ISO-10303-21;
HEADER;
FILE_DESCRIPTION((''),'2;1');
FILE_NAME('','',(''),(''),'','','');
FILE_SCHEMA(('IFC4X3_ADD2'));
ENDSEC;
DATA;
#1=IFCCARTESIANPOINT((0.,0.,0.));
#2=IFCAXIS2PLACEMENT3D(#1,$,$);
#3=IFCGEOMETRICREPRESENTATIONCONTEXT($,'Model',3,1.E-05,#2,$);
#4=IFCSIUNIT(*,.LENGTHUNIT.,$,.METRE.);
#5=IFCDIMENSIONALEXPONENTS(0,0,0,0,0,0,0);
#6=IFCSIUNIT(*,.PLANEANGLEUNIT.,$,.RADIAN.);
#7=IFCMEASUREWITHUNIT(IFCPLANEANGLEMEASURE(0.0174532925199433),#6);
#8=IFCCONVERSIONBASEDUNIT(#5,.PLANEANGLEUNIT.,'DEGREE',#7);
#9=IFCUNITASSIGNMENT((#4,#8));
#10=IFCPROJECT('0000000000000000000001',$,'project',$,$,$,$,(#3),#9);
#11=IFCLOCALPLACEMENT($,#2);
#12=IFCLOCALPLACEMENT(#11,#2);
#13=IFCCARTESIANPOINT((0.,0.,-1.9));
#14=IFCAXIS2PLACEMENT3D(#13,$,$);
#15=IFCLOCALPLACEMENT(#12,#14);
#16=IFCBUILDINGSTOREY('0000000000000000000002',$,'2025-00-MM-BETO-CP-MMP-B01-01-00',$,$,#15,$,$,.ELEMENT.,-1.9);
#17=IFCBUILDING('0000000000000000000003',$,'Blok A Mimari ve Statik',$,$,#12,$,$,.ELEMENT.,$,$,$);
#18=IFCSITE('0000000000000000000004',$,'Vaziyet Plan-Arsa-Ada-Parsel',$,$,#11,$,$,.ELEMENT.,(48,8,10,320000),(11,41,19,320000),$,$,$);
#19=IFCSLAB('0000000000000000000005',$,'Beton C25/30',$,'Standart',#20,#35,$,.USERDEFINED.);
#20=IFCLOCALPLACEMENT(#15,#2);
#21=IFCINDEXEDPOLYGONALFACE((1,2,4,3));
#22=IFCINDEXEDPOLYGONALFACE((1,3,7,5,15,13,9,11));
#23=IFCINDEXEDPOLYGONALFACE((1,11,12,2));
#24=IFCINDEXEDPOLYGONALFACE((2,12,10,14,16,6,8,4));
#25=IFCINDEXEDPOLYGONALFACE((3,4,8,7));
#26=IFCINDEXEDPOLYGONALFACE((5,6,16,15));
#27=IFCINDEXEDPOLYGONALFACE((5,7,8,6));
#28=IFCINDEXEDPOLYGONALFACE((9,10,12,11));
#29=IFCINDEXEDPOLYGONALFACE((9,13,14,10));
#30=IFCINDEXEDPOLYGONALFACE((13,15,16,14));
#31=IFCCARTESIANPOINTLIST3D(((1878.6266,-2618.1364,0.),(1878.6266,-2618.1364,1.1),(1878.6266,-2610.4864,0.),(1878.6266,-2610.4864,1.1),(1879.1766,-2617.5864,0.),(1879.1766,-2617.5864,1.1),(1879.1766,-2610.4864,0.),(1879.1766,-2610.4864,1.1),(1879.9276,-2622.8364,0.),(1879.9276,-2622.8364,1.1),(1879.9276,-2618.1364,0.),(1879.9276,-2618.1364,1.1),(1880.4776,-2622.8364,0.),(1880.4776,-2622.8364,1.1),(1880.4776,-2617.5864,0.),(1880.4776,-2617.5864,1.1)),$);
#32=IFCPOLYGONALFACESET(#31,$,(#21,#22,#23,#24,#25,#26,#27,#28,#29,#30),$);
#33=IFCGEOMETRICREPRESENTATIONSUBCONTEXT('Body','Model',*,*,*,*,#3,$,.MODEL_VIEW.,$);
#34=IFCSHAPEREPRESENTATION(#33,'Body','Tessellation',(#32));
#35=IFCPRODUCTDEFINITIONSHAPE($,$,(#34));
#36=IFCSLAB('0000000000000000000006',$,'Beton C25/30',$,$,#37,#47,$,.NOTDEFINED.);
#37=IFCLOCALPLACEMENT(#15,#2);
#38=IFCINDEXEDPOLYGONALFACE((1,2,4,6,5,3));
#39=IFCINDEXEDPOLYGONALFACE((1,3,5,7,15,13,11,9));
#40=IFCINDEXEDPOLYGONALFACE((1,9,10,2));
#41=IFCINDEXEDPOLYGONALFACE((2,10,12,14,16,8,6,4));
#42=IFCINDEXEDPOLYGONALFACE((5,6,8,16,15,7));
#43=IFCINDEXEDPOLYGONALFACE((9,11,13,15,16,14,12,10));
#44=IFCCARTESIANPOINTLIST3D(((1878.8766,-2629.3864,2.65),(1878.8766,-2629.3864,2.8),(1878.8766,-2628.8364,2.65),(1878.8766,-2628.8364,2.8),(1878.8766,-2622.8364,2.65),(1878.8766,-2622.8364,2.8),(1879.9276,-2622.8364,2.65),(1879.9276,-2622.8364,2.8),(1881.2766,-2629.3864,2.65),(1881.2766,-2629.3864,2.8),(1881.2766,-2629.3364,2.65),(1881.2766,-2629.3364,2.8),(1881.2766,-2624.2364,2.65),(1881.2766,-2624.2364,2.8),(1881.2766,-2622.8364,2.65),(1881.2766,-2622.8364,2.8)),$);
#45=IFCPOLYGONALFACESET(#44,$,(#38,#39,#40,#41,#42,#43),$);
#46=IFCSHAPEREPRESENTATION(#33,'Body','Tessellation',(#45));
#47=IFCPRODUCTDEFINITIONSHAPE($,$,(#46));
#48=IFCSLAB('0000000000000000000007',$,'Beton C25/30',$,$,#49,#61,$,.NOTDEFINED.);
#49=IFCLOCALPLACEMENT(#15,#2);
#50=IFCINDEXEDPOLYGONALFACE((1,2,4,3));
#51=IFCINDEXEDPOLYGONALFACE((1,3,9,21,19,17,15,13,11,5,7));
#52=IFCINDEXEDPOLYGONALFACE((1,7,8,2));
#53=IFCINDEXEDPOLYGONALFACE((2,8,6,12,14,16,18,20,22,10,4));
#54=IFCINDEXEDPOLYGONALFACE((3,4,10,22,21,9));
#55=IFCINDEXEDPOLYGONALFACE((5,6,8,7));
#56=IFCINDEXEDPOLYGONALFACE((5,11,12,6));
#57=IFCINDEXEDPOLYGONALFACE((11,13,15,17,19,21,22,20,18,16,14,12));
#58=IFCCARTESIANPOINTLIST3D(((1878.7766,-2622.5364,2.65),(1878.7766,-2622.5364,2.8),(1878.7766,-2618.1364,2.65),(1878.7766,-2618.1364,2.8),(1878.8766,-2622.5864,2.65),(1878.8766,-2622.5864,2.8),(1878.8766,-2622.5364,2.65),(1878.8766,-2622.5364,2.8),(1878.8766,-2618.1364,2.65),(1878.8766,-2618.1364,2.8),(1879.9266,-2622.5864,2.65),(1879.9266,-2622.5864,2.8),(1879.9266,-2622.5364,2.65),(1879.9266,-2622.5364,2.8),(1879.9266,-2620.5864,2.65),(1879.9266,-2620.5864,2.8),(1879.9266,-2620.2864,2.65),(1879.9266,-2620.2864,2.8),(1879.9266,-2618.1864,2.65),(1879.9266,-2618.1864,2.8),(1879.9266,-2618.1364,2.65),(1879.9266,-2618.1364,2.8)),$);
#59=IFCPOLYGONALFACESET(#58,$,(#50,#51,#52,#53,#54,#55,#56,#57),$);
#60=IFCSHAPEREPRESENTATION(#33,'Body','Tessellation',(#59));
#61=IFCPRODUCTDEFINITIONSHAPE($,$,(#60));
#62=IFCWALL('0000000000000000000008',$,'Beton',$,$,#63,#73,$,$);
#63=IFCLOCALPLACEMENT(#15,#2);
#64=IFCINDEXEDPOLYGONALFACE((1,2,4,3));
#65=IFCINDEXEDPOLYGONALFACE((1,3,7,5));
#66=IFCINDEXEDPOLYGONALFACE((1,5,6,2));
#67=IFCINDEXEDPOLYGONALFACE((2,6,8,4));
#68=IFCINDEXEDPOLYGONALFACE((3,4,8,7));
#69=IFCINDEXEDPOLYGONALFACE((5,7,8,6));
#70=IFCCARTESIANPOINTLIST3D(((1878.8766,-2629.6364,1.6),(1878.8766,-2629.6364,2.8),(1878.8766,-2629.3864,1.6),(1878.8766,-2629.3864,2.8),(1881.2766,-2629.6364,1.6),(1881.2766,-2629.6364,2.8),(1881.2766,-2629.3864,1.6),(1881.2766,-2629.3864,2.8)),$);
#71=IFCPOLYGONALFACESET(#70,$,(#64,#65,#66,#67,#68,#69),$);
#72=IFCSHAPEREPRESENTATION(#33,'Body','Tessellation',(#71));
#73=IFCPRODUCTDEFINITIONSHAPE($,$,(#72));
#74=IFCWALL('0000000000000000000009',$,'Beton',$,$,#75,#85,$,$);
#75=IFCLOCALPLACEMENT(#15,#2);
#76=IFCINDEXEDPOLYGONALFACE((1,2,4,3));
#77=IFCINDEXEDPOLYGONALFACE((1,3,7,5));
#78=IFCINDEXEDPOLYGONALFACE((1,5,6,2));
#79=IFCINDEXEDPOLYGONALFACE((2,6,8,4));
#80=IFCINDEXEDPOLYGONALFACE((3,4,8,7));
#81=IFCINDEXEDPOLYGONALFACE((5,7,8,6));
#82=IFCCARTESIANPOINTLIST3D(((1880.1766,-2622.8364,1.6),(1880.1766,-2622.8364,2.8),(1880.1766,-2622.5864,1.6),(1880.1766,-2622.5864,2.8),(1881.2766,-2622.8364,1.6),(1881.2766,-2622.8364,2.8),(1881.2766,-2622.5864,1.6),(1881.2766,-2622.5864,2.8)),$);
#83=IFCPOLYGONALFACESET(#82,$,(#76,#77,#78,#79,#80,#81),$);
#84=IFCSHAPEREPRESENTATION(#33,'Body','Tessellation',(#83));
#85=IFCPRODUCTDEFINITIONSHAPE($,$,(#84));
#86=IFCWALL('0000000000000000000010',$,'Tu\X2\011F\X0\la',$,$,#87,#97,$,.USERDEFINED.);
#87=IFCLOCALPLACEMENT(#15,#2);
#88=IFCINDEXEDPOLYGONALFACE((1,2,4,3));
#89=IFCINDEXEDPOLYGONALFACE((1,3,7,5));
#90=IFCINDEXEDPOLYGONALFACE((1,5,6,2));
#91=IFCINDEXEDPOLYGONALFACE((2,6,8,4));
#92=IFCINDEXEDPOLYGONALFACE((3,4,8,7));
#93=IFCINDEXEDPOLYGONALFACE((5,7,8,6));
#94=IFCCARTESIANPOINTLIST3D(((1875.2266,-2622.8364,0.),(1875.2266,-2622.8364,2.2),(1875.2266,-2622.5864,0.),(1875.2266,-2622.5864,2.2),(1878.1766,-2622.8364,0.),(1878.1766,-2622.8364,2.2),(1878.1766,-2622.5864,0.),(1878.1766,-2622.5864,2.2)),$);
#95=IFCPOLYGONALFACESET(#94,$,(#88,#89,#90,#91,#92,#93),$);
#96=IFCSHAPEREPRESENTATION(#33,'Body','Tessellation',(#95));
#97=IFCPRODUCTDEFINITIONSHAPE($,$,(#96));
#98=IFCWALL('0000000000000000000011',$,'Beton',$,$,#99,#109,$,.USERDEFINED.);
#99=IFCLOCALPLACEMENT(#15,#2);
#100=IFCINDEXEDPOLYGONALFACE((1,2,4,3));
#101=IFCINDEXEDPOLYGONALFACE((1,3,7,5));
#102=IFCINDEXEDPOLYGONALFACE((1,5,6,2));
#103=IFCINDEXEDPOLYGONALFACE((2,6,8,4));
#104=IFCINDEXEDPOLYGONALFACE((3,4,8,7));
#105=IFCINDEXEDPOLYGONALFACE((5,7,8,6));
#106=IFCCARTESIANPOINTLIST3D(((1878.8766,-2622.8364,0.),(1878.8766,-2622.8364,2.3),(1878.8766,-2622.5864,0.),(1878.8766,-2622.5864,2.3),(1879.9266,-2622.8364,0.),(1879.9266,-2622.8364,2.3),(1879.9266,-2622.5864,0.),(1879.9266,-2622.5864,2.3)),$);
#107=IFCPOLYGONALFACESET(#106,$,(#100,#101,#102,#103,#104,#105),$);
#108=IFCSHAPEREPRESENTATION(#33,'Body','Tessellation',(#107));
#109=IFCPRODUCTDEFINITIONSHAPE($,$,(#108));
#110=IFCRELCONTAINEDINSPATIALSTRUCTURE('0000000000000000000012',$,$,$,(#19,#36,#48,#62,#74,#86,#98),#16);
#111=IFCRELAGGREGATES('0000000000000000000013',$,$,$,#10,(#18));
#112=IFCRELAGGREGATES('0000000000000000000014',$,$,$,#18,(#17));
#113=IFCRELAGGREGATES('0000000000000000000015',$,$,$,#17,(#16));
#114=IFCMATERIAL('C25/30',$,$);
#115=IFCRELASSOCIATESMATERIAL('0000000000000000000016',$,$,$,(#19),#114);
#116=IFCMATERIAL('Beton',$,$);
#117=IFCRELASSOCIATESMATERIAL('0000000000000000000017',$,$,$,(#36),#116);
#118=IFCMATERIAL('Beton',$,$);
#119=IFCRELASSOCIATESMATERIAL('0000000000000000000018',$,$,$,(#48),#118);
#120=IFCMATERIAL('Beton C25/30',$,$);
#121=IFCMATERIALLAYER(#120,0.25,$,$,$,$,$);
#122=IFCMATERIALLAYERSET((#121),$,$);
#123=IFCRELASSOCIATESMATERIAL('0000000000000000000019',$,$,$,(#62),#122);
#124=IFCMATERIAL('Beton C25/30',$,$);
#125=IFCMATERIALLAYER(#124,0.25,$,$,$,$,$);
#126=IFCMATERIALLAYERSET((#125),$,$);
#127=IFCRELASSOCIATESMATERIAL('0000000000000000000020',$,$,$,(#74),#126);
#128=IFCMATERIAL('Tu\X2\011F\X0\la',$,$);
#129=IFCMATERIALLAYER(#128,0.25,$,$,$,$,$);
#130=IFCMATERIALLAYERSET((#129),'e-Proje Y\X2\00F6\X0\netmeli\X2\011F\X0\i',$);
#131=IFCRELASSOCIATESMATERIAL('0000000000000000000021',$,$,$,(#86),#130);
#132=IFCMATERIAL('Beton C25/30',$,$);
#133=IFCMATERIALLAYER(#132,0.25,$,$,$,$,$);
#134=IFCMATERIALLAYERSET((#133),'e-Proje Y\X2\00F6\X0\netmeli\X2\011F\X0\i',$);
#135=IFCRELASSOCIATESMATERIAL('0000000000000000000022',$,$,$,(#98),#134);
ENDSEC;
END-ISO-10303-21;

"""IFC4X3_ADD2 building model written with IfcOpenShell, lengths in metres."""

from ifc_helpers import new_model, entity, si_unit, converted_unit, frame, frame_2d, origin, origin_with_axes, place, context, subcontext, project, spatial, polyline, rectangle, outline, extrude, material, layer, layer_set, layer_usage, element, save


model = new_model("IFC4X3_ADD2")

# Units and contexts
model_context = context("Model", 3, precision=1e-05, world=origin())
body_context = subcontext(model_context, "Body", "Model", "MODEL_VIEW")
ifc_project = project(units=[si_unit("LENGTHUNIT", "METRE"), converted_unit("PLANEANGLEUNIT", "DEGREE", entity("IfcPlaneAngleMeasure", 0.0174532925199433), si_unit("PLANEANGLEUNIT", "RADIAN"), dimensions=[0, 0, 0, 0, 0, 0, 0])], contexts=[model_context])

# Site, building, storey
site_placement = place(None, origin())
site = spatial("IfcSite", under=ifc_project, at=site_placement, Name="Vaziyet Plan-Arsa-Ada-Parsel", CompositionType="ELEMENT", RefLatitude=(48, 8, 10, 320000), RefLongitude=(11, 41, 19, 320000))
building_placement = place(site_placement, origin())
building = spatial("IfcBuilding", under=site, at=building_placement, Name="Blok A Mimari ve Statik", CompositionType="ELEMENT")
storey_placement = place(building_placement, frame((0.0, 0.0, -1.9)))
storey = spatial("IfcBuildingStorey", under=building, at=storey_placement, Name="2025-00-MM-BETO-CP-MMP-B01-01-00", CompositionType="ELEMENT", Elevation=-1.9)

# Slabs
ifc_material_1 = material(Name="C25/30")
slab_1_placement = place(storey_placement, frame((1878.6266, -2622.8364, 0.0)))
element("IfcSlab", 1, at=slab_1_placement, inside=storey, material=ifc_material_1, Name="Beton C25/30", ObjectType="Standart", PredefinedType="USERDEFINED", context=body_context, shape_type="SweptSolid", body=[
    extrude(outline(polyline([(0.0, 4.7), (1.301, 4.7), (1.301, 0.0), (1.851, 0.0), (1.851, 5.25), (0.55, 5.25), (0.55, 12.35), (0.0, 12.35), (0.0, 4.7)])), origin_with_axes(), (0.0, 0.0, 1.0), 1.1),
])
ifc_material_2 = material(Name="Beton")
slab_2_placement = place(storey_placement, frame((1878.8766, -2629.3864, 2.65)))
element("IfcSlab", 2, at=slab_2_placement, inside=storey, material=ifc_material_2, Name="Beton C25/30", PredefinedType="NOTDEFINED", context=body_context, shape_type="SweptSolid", body=[
    extrude(outline(polyline([(1.051, 6.55), (0.0, 6.55), (0.0, 0.55), (0.0, 0.0), (2.4, 0.0), (2.4, 0.05), (2.4, 5.15), (2.4, 6.55), (1.051, 6.55)])), origin_with_axes(), (0.0, 0.0, 1.0), 0.15),
])
ifc_material_3 = material(Name="Beton")
slab_3_placement = place(storey_placement, frame((1878.7766, -2622.5864, 2.65)))
element("IfcSlab", 3, at=slab_3_placement, inside=storey, material=ifc_material_3, Name="Beton C25/30", PredefinedType="NOTDEFINED", context=body_context, shape_type="SweptSolid", body=[
    extrude(outline(polyline([(0.1, 4.45), (0.0, 4.45), (0.0, 0.05), (0.1, 0.05), (0.1, 0.0), (1.15, 0.0), (1.15, 0.05), (1.15, 2.0), (1.15, 2.3), (1.15, 4.4), (1.15, 4.45), (0.1, 4.45)])), origin_with_axes(), (0.0, 0.0, 1.0), 0.15),
])

# Walls
ifc_material_4 = material(Name="Beton C25/30")
ifc_layer_1 = layer(ifc_material_4, 0.25)
ifc_layer_set_1 = layer_set([ifc_layer_1])
ifc_layer_usage_1 = layer_usage(ifc_layer_set_1, "AXIS2", "POSITIVE", 0.0)
wall_1_placement = place(storey_placement, frame((1878.8766, -2629.6364, 1.6)))
element("IfcWall", 4, at=wall_1_placement, inside=storey, material=ifc_layer_usage_1, Name="Beton", context=body_context, shape_type="SweptSolid", body=[
    extrude(rectangle(XDim=2.4, YDim=0.25, at=frame_2d((1.2, 0.125), x_axis=(1.0, 0.0))), origin_with_axes(), (0.0, 0.0, 1.0), 1.2),
])
ifc_material_5 = material(Name="Beton C25/30")
ifc_layer_2 = layer(ifc_material_5, 0.25)
ifc_layer_set_2 = layer_set([ifc_layer_2])
ifc_layer_usage_2 = layer_usage(ifc_layer_set_2, "AXIS2", "POSITIVE", 0.0)
wall_2_placement = place(storey_placement, frame((1880.1766, -2622.8364, 1.6)))
element("IfcWall", 5, at=wall_2_placement, inside=storey, material=ifc_layer_usage_2, Name="Beton", context=body_context, shape_type="SweptSolid", body=[
    extrude(rectangle(XDim=1.1, YDim=0.25, at=frame_2d((0.55, 0.125), x_axis=(1.0, 0.0))), origin_with_axes(), (0.0, 0.0, 1.0), 1.2),
])
ifc_material_6 = material(Name="Tuğla")
ifc_layer_3 = layer(ifc_material_6, 0.25)
ifc_layer_set_3 = layer_set([ifc_layer_3], Name="e-Proje Yönetmeliği")
ifc_layer_usage_3 = layer_usage(ifc_layer_set_3, "AXIS2", "POSITIVE", 0.0)
wall_3_placement = place(storey_placement, frame((1875.2266, -2622.8364, 0.0)))
element("IfcWall", 6, at=wall_3_placement, inside=storey, material=ifc_layer_usage_3, Name="Tuğla", PredefinedType="USERDEFINED", context=body_context, shape_type="SweptSolid", body=[
    extrude(rectangle(XDim=2.95, YDim=0.25, at=frame_2d((1.475, 0.125), x_axis=(1.0, 0.0))), origin_with_axes(), (0.0, 0.0, 1.0), 2.2),
])
ifc_material_7 = material(Name="Beton C25/30")
ifc_layer_4 = layer(ifc_material_7, 0.25)
ifc_layer_set_4 = layer_set([ifc_layer_4], Name="e-Proje Yönetmeliği")
ifc_layer_usage_4 = layer_usage(ifc_layer_set_4, "AXIS2", "POSITIVE", 0.0)
wall_4_placement = place(storey_placement, frame((1878.8766, -2622.8364, 0.0)))
element("IfcWall", 7, at=wall_4_placement, inside=storey, material=ifc_layer_usage_4, Name="Beton", PredefinedType="USERDEFINED", context=body_context, shape_type="SweptSolid", body=[
    extrude(rectangle(XDim=1.05, YDim=0.25, at=frame_2d((0.525, 0.125), x_axis=(1.0, 0.0))), origin_with_axes(), (0.0, 0.0, 1.0), 2.3),
])

save(model, "model.ifc")
